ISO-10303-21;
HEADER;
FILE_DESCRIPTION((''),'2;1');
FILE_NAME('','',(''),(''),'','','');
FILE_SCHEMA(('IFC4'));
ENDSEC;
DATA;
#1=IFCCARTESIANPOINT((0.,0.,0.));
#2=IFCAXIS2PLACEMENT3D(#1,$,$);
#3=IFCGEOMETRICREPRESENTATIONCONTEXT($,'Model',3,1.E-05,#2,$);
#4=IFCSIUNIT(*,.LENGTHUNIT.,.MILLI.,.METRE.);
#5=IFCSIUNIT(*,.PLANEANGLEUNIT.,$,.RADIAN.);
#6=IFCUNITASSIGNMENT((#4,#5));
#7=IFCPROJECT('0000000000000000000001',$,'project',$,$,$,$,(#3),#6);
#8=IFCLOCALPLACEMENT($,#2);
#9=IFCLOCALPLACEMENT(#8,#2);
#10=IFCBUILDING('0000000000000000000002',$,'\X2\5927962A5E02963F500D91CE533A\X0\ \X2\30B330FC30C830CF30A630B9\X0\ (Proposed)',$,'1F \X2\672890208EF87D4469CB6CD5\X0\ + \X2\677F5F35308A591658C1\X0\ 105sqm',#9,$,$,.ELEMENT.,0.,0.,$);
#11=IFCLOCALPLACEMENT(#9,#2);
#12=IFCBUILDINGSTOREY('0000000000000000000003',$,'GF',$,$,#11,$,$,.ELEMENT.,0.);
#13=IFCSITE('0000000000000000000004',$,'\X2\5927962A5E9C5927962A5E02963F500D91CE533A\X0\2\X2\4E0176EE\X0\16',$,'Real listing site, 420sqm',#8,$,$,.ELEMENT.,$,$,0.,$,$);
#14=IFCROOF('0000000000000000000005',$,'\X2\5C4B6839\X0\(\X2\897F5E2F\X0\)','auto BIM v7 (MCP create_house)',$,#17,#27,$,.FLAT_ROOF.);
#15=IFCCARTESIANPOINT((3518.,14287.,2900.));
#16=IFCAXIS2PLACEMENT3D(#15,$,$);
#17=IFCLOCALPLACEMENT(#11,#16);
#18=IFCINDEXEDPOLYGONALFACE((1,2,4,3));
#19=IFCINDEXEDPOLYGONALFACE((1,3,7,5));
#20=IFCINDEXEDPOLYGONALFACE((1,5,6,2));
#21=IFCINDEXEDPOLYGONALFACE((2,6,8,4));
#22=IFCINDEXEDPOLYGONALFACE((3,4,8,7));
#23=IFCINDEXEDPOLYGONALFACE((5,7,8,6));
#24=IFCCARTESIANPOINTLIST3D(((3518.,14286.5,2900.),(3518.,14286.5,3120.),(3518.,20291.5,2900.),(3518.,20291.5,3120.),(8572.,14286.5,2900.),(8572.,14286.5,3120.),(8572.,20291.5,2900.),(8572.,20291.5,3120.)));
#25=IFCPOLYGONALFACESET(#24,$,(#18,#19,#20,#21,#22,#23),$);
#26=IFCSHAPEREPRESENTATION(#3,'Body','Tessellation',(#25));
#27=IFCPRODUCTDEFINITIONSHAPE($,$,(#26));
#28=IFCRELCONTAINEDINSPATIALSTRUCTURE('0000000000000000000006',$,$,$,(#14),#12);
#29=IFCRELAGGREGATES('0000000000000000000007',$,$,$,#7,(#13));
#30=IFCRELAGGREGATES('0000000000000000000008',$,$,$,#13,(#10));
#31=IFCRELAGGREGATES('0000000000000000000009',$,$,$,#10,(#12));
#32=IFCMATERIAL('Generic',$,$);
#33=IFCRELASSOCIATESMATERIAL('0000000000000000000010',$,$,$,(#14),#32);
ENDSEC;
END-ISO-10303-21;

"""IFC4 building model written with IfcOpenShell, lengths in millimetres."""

from ifc_helpers import new_model, si_unit, frame, frame_2d, origin, place, context, project, spatial, rectangle, extrude, material, element, save


model = new_model("IFC4")

# Units and contexts
model_context = context("Model", 3, precision=1e-05, world=origin())
ifc_project = project(units=[si_unit("LENGTHUNIT", "METRE", prefix="MILLI"), si_unit("PLANEANGLEUNIT", "RADIAN")], contexts=[model_context])

# Site, building, storey
site_placement = place(None, origin())
site = spatial("IfcSite", under=ifc_project, at=site_placement, Name="大阪府大阪市阿倍野区2丁目16", ObjectType="Real listing site, 420sqm", CompositionType="ELEMENT", RefElevation=0.0)
building_placement = place(site_placement, origin())
building = spatial("IfcBuilding", under=site, at=building_placement, Name="大阪市阿倍野区 コートハウス (Proposed)", ObjectType="1F 木造軸組構法 + 板張り外壁 105sqm", CompositionType="ELEMENT", ElevationOfRefHeight=0.0, ElevationOfTerrain=0.0)
storey_placement = place(building_placement, origin())
storey = spatial("IfcBuildingStorey", under=building, at=storey_placement, Name="GF", CompositionType="ELEMENT", Elevation=0.0)

# Shared definitions
ifc_material = material(Name="Generic")

# Roof
roof_1_placement = place(storey_placement, frame((3518.0, 14287.0, 2900.0)))
element("IfcRoof", 1, at=roof_1_placement, inside=storey, material=ifc_material, Name="屋根(西帯)", Description="auto BIM v7 (MCP create_house)", PredefinedType="FLAT_ROOF", context=model_context, shape_type="SweptSolid", body=[
    extrude(rectangle(XDim=5054.0, YDim=6005.0, at=frame_2d((2527.0, 3002.0))), frame((3518.0, 14287.0, 2900.0)), (0.0, 0.0, 1.0), 220.0),
])

save(model, "model.ifc")
